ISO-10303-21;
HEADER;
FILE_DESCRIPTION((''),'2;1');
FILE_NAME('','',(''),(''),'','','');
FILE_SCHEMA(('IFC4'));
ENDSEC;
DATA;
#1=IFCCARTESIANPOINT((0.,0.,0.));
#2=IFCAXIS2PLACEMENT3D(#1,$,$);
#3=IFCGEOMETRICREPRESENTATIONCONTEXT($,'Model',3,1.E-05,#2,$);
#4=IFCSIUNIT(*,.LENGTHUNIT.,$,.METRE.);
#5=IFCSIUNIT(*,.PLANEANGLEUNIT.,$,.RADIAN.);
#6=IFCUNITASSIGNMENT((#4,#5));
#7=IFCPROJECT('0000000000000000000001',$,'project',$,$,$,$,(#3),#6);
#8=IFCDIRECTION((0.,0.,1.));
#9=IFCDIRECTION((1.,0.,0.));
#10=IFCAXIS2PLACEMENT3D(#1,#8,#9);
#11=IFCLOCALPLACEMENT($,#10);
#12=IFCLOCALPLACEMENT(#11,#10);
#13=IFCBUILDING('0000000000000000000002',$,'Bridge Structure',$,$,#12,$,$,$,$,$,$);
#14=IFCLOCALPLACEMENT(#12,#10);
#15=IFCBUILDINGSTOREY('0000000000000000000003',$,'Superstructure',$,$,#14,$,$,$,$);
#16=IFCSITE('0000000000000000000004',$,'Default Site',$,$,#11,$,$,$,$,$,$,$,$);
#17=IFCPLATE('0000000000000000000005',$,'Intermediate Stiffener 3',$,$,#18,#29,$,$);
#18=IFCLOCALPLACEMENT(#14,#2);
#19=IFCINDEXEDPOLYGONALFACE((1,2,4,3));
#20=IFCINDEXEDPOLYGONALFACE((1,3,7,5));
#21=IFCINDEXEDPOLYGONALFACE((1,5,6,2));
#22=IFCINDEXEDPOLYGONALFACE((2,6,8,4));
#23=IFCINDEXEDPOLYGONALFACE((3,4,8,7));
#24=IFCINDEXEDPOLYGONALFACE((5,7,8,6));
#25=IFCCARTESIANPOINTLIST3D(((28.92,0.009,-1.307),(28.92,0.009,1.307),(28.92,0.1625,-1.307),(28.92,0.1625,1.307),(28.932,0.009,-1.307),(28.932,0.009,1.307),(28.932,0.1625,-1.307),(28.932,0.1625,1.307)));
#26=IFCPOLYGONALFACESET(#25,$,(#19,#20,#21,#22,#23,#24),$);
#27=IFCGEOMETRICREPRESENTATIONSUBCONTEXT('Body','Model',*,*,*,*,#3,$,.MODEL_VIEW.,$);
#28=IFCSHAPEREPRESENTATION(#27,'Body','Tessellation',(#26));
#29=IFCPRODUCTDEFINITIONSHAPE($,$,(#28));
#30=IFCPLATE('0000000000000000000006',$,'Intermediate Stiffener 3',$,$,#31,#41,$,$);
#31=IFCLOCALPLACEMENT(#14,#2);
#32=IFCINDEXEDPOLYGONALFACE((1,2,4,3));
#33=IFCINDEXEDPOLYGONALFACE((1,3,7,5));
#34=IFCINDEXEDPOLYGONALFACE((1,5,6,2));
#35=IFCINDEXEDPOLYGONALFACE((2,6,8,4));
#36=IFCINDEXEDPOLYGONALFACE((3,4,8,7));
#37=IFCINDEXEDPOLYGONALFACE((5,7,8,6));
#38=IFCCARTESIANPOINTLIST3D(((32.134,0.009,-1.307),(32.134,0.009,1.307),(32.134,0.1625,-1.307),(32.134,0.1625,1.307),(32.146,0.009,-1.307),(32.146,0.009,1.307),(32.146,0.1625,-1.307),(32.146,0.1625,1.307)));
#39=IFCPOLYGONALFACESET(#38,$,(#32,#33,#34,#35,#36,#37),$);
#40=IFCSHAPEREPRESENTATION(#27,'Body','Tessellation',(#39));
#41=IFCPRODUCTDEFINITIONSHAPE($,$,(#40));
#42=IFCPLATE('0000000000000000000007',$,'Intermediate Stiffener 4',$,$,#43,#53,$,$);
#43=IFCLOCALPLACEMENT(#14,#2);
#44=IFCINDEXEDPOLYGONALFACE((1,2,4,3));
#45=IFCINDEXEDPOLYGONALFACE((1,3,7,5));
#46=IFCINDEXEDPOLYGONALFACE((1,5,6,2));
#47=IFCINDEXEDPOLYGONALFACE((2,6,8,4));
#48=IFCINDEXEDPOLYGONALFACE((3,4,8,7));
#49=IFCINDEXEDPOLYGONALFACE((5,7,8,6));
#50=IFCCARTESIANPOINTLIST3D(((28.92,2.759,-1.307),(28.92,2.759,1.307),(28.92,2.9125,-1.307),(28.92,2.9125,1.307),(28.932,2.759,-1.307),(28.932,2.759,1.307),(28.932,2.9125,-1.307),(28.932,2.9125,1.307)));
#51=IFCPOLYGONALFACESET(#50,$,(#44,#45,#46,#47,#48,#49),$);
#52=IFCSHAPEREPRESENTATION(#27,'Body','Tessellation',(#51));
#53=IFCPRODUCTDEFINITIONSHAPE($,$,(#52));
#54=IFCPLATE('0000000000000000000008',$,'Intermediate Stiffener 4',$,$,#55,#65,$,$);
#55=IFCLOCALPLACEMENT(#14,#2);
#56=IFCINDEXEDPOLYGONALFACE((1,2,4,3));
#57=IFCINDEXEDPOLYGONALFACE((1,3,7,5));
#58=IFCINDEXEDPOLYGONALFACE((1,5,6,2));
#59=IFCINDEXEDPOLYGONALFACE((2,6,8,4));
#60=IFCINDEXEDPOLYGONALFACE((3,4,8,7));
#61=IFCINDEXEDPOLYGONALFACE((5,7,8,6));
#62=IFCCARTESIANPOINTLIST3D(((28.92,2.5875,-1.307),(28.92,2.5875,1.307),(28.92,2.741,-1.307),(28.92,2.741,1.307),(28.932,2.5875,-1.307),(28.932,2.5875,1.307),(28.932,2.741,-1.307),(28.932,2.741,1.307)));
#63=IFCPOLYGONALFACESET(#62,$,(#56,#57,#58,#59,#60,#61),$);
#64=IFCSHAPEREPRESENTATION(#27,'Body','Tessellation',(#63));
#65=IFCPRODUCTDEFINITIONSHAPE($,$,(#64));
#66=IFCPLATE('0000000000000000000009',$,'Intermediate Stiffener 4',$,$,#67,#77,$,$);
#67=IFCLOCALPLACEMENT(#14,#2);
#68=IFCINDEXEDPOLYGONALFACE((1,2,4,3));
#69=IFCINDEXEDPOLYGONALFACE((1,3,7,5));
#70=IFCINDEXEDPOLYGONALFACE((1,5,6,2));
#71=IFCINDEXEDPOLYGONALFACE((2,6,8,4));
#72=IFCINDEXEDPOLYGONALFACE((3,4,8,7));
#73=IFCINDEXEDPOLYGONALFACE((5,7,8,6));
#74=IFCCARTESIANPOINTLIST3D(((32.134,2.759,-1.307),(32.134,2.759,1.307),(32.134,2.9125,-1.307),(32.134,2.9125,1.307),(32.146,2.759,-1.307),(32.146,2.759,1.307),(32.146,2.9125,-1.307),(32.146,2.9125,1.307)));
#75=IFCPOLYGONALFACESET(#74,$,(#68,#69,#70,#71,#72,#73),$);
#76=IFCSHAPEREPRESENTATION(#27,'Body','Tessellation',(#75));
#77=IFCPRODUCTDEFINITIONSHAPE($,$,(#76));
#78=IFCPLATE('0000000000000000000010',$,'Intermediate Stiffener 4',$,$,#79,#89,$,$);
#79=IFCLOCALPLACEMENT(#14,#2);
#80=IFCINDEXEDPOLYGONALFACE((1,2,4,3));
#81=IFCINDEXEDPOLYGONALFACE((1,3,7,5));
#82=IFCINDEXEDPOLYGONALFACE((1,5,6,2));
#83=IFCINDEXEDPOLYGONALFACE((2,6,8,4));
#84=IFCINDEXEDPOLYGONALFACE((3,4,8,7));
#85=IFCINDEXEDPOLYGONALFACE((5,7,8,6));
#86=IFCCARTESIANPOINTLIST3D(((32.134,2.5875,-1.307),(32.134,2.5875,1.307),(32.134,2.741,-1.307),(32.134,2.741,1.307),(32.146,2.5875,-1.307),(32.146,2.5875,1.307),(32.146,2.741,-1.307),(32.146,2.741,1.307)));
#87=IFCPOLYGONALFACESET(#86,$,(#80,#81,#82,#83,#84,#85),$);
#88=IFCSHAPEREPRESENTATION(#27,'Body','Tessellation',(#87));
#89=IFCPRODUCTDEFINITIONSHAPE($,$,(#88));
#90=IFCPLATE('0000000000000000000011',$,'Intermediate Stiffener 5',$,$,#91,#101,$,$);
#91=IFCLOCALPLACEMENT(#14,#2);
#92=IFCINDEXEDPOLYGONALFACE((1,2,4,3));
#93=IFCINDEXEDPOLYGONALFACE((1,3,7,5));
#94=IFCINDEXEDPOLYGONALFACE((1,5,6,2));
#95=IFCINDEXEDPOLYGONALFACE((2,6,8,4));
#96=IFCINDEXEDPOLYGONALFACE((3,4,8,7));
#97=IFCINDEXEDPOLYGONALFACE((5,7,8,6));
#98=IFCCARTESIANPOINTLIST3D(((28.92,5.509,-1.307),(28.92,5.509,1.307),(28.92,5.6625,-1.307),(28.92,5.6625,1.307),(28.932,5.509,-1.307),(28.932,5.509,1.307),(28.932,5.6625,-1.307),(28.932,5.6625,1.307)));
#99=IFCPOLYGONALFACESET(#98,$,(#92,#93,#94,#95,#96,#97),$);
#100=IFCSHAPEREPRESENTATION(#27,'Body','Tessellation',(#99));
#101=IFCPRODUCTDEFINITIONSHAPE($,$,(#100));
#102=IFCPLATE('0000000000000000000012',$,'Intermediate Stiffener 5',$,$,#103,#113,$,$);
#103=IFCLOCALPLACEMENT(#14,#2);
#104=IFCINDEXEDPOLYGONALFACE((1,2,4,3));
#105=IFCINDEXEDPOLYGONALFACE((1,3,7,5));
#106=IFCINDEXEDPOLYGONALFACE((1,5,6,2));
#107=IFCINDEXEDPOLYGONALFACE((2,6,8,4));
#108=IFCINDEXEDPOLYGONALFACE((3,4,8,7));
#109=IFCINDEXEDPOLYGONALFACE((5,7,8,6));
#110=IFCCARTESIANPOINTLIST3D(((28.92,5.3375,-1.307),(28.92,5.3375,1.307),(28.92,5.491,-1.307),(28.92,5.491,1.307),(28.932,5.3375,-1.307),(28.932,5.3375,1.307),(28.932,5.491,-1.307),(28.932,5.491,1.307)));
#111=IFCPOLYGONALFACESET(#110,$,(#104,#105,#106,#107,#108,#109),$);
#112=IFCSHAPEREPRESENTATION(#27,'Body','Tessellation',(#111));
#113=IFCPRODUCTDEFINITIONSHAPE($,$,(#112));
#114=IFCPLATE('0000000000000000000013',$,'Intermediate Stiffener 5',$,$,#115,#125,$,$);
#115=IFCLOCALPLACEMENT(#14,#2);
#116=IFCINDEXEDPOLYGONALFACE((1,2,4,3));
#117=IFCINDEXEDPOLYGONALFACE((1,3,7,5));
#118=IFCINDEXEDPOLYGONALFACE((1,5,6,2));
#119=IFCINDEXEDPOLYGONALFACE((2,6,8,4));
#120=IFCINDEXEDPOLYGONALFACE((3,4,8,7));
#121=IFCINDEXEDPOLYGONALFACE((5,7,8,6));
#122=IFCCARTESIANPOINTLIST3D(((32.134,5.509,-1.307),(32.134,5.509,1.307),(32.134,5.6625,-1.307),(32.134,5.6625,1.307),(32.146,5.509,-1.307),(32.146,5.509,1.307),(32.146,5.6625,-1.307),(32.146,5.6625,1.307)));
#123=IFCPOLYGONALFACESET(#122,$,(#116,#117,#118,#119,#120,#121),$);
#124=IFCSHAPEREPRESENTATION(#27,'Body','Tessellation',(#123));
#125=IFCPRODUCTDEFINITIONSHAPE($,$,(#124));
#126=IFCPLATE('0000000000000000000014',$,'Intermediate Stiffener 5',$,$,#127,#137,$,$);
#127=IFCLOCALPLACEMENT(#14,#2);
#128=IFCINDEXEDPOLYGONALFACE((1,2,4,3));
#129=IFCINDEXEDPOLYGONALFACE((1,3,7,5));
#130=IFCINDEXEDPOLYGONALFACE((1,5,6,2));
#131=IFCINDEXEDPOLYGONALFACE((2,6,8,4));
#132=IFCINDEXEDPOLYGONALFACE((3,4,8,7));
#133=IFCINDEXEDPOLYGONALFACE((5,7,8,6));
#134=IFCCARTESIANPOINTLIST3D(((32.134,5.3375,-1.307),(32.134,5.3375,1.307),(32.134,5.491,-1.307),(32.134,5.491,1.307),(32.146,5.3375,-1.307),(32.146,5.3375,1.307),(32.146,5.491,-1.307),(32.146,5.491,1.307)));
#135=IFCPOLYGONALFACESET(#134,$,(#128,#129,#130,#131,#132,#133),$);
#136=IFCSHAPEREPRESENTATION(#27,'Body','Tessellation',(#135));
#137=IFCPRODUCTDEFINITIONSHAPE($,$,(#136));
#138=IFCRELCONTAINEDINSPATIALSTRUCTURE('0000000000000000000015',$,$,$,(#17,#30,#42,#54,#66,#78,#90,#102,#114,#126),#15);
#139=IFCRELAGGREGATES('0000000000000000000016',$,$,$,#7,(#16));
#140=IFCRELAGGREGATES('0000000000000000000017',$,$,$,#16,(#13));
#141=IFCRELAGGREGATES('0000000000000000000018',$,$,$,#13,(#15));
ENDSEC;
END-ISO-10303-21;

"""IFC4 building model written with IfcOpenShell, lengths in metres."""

from ifc_helpers import new_model, si_unit, frame, origin, origin_with_axes, origin_2d_with_axis, place, context, subcontext, project, spatial, rectangle, extrude, element, save


model = new_model("IFC4")

# Units and contexts
model_context = context("Model", 3, precision=1e-05, world=origin())
body_context = subcontext(model_context, "Body", "Model", "MODEL_VIEW")
ifc_project = project(units=[si_unit("LENGTHUNIT", "METRE"), si_unit("PLANEANGLEUNIT", "RADIAN")], contexts=[model_context])

# Site, building, storey
site_placement = place(None, origin_with_axes())
site = spatial("IfcSite", under=ifc_project, at=site_placement, Name="Default Site")
building_placement = place(site_placement, origin_with_axes())
building = spatial("IfcBuilding", under=site, at=building_placement, Name="Bridge Structure")
storey_placement = place(building_placement, origin_with_axes())
storey = spatial("IfcBuildingStorey", under=building, at=storey_placement, Name="Superstructure")

# Plates
for number, where, z_axis, x_axis, name in (
    (1, (28.926, 0.0858, -1.307), (0.0, 0.0, 1.0), (1.0, 0.0, 0.0), "Intermediate Stiffener 3"),
    (2, (32.14, 0.0858, -1.307), (0.0, 0.0, 1.0), (1.0, 0.0, 0.0), "Intermediate Stiffener 3"),
    (3, (28.926, 2.8357, -1.307), (0.0, 0.0, 1.0), (1.0, 0.0, 0.0), "Intermediate Stiffener 4"),
    (4, (28.926, 2.6643, -1.307), (0.0, 0.0, 1.0), (1.0, 0.0, 0.0), "Intermediate Stiffener 4"),
    (5, (32.14, 2.8357, -1.307), (0.0, 0.0, 1.0), (1.0, 0.0, 0.0), "Intermediate Stiffener 4"),
    (6, (32.14, 2.6643, -1.307), (0.0, 0.0, 1.0), (1.0, 0.0, 0.0), "Intermediate Stiffener 4"),
    (7, (28.926, 5.5857, -1.307), (0.0, 0.0, 1.0), (1.0, 0.0, 0.0), "Intermediate Stiffener 5"),
    (8, (28.926, 5.4143, -1.307), (0.0, 0.0, 1.0), (1.0, 0.0, 0.0), "Intermediate Stiffener 5"),
    (9, (32.14, 5.5857, -1.307), (0.0, 0.0, 1.0), (1.0, 0.0, 0.0), "Intermediate Stiffener 5"),
    (10, (32.14, 5.4143, -1.307), (0.0, 0.0, 1.0), (1.0, 0.0, 0.0), "Intermediate Stiffener 5"),
):
    element("IfcPlate", number, at=place(storey_placement, frame(where, z_axis=z_axis, x_axis=x_axis)), inside=storey, Name=name, context=body_context, shape_type="SweptSolid", body=[
        extrude(rectangle(XDim=0.012, YDim=0.1535, at=origin_2d_with_axis()), origin_with_axes(), (0.0, 0.0, 1.0), 2.614),
    ])

save(model, "model.ifc")
